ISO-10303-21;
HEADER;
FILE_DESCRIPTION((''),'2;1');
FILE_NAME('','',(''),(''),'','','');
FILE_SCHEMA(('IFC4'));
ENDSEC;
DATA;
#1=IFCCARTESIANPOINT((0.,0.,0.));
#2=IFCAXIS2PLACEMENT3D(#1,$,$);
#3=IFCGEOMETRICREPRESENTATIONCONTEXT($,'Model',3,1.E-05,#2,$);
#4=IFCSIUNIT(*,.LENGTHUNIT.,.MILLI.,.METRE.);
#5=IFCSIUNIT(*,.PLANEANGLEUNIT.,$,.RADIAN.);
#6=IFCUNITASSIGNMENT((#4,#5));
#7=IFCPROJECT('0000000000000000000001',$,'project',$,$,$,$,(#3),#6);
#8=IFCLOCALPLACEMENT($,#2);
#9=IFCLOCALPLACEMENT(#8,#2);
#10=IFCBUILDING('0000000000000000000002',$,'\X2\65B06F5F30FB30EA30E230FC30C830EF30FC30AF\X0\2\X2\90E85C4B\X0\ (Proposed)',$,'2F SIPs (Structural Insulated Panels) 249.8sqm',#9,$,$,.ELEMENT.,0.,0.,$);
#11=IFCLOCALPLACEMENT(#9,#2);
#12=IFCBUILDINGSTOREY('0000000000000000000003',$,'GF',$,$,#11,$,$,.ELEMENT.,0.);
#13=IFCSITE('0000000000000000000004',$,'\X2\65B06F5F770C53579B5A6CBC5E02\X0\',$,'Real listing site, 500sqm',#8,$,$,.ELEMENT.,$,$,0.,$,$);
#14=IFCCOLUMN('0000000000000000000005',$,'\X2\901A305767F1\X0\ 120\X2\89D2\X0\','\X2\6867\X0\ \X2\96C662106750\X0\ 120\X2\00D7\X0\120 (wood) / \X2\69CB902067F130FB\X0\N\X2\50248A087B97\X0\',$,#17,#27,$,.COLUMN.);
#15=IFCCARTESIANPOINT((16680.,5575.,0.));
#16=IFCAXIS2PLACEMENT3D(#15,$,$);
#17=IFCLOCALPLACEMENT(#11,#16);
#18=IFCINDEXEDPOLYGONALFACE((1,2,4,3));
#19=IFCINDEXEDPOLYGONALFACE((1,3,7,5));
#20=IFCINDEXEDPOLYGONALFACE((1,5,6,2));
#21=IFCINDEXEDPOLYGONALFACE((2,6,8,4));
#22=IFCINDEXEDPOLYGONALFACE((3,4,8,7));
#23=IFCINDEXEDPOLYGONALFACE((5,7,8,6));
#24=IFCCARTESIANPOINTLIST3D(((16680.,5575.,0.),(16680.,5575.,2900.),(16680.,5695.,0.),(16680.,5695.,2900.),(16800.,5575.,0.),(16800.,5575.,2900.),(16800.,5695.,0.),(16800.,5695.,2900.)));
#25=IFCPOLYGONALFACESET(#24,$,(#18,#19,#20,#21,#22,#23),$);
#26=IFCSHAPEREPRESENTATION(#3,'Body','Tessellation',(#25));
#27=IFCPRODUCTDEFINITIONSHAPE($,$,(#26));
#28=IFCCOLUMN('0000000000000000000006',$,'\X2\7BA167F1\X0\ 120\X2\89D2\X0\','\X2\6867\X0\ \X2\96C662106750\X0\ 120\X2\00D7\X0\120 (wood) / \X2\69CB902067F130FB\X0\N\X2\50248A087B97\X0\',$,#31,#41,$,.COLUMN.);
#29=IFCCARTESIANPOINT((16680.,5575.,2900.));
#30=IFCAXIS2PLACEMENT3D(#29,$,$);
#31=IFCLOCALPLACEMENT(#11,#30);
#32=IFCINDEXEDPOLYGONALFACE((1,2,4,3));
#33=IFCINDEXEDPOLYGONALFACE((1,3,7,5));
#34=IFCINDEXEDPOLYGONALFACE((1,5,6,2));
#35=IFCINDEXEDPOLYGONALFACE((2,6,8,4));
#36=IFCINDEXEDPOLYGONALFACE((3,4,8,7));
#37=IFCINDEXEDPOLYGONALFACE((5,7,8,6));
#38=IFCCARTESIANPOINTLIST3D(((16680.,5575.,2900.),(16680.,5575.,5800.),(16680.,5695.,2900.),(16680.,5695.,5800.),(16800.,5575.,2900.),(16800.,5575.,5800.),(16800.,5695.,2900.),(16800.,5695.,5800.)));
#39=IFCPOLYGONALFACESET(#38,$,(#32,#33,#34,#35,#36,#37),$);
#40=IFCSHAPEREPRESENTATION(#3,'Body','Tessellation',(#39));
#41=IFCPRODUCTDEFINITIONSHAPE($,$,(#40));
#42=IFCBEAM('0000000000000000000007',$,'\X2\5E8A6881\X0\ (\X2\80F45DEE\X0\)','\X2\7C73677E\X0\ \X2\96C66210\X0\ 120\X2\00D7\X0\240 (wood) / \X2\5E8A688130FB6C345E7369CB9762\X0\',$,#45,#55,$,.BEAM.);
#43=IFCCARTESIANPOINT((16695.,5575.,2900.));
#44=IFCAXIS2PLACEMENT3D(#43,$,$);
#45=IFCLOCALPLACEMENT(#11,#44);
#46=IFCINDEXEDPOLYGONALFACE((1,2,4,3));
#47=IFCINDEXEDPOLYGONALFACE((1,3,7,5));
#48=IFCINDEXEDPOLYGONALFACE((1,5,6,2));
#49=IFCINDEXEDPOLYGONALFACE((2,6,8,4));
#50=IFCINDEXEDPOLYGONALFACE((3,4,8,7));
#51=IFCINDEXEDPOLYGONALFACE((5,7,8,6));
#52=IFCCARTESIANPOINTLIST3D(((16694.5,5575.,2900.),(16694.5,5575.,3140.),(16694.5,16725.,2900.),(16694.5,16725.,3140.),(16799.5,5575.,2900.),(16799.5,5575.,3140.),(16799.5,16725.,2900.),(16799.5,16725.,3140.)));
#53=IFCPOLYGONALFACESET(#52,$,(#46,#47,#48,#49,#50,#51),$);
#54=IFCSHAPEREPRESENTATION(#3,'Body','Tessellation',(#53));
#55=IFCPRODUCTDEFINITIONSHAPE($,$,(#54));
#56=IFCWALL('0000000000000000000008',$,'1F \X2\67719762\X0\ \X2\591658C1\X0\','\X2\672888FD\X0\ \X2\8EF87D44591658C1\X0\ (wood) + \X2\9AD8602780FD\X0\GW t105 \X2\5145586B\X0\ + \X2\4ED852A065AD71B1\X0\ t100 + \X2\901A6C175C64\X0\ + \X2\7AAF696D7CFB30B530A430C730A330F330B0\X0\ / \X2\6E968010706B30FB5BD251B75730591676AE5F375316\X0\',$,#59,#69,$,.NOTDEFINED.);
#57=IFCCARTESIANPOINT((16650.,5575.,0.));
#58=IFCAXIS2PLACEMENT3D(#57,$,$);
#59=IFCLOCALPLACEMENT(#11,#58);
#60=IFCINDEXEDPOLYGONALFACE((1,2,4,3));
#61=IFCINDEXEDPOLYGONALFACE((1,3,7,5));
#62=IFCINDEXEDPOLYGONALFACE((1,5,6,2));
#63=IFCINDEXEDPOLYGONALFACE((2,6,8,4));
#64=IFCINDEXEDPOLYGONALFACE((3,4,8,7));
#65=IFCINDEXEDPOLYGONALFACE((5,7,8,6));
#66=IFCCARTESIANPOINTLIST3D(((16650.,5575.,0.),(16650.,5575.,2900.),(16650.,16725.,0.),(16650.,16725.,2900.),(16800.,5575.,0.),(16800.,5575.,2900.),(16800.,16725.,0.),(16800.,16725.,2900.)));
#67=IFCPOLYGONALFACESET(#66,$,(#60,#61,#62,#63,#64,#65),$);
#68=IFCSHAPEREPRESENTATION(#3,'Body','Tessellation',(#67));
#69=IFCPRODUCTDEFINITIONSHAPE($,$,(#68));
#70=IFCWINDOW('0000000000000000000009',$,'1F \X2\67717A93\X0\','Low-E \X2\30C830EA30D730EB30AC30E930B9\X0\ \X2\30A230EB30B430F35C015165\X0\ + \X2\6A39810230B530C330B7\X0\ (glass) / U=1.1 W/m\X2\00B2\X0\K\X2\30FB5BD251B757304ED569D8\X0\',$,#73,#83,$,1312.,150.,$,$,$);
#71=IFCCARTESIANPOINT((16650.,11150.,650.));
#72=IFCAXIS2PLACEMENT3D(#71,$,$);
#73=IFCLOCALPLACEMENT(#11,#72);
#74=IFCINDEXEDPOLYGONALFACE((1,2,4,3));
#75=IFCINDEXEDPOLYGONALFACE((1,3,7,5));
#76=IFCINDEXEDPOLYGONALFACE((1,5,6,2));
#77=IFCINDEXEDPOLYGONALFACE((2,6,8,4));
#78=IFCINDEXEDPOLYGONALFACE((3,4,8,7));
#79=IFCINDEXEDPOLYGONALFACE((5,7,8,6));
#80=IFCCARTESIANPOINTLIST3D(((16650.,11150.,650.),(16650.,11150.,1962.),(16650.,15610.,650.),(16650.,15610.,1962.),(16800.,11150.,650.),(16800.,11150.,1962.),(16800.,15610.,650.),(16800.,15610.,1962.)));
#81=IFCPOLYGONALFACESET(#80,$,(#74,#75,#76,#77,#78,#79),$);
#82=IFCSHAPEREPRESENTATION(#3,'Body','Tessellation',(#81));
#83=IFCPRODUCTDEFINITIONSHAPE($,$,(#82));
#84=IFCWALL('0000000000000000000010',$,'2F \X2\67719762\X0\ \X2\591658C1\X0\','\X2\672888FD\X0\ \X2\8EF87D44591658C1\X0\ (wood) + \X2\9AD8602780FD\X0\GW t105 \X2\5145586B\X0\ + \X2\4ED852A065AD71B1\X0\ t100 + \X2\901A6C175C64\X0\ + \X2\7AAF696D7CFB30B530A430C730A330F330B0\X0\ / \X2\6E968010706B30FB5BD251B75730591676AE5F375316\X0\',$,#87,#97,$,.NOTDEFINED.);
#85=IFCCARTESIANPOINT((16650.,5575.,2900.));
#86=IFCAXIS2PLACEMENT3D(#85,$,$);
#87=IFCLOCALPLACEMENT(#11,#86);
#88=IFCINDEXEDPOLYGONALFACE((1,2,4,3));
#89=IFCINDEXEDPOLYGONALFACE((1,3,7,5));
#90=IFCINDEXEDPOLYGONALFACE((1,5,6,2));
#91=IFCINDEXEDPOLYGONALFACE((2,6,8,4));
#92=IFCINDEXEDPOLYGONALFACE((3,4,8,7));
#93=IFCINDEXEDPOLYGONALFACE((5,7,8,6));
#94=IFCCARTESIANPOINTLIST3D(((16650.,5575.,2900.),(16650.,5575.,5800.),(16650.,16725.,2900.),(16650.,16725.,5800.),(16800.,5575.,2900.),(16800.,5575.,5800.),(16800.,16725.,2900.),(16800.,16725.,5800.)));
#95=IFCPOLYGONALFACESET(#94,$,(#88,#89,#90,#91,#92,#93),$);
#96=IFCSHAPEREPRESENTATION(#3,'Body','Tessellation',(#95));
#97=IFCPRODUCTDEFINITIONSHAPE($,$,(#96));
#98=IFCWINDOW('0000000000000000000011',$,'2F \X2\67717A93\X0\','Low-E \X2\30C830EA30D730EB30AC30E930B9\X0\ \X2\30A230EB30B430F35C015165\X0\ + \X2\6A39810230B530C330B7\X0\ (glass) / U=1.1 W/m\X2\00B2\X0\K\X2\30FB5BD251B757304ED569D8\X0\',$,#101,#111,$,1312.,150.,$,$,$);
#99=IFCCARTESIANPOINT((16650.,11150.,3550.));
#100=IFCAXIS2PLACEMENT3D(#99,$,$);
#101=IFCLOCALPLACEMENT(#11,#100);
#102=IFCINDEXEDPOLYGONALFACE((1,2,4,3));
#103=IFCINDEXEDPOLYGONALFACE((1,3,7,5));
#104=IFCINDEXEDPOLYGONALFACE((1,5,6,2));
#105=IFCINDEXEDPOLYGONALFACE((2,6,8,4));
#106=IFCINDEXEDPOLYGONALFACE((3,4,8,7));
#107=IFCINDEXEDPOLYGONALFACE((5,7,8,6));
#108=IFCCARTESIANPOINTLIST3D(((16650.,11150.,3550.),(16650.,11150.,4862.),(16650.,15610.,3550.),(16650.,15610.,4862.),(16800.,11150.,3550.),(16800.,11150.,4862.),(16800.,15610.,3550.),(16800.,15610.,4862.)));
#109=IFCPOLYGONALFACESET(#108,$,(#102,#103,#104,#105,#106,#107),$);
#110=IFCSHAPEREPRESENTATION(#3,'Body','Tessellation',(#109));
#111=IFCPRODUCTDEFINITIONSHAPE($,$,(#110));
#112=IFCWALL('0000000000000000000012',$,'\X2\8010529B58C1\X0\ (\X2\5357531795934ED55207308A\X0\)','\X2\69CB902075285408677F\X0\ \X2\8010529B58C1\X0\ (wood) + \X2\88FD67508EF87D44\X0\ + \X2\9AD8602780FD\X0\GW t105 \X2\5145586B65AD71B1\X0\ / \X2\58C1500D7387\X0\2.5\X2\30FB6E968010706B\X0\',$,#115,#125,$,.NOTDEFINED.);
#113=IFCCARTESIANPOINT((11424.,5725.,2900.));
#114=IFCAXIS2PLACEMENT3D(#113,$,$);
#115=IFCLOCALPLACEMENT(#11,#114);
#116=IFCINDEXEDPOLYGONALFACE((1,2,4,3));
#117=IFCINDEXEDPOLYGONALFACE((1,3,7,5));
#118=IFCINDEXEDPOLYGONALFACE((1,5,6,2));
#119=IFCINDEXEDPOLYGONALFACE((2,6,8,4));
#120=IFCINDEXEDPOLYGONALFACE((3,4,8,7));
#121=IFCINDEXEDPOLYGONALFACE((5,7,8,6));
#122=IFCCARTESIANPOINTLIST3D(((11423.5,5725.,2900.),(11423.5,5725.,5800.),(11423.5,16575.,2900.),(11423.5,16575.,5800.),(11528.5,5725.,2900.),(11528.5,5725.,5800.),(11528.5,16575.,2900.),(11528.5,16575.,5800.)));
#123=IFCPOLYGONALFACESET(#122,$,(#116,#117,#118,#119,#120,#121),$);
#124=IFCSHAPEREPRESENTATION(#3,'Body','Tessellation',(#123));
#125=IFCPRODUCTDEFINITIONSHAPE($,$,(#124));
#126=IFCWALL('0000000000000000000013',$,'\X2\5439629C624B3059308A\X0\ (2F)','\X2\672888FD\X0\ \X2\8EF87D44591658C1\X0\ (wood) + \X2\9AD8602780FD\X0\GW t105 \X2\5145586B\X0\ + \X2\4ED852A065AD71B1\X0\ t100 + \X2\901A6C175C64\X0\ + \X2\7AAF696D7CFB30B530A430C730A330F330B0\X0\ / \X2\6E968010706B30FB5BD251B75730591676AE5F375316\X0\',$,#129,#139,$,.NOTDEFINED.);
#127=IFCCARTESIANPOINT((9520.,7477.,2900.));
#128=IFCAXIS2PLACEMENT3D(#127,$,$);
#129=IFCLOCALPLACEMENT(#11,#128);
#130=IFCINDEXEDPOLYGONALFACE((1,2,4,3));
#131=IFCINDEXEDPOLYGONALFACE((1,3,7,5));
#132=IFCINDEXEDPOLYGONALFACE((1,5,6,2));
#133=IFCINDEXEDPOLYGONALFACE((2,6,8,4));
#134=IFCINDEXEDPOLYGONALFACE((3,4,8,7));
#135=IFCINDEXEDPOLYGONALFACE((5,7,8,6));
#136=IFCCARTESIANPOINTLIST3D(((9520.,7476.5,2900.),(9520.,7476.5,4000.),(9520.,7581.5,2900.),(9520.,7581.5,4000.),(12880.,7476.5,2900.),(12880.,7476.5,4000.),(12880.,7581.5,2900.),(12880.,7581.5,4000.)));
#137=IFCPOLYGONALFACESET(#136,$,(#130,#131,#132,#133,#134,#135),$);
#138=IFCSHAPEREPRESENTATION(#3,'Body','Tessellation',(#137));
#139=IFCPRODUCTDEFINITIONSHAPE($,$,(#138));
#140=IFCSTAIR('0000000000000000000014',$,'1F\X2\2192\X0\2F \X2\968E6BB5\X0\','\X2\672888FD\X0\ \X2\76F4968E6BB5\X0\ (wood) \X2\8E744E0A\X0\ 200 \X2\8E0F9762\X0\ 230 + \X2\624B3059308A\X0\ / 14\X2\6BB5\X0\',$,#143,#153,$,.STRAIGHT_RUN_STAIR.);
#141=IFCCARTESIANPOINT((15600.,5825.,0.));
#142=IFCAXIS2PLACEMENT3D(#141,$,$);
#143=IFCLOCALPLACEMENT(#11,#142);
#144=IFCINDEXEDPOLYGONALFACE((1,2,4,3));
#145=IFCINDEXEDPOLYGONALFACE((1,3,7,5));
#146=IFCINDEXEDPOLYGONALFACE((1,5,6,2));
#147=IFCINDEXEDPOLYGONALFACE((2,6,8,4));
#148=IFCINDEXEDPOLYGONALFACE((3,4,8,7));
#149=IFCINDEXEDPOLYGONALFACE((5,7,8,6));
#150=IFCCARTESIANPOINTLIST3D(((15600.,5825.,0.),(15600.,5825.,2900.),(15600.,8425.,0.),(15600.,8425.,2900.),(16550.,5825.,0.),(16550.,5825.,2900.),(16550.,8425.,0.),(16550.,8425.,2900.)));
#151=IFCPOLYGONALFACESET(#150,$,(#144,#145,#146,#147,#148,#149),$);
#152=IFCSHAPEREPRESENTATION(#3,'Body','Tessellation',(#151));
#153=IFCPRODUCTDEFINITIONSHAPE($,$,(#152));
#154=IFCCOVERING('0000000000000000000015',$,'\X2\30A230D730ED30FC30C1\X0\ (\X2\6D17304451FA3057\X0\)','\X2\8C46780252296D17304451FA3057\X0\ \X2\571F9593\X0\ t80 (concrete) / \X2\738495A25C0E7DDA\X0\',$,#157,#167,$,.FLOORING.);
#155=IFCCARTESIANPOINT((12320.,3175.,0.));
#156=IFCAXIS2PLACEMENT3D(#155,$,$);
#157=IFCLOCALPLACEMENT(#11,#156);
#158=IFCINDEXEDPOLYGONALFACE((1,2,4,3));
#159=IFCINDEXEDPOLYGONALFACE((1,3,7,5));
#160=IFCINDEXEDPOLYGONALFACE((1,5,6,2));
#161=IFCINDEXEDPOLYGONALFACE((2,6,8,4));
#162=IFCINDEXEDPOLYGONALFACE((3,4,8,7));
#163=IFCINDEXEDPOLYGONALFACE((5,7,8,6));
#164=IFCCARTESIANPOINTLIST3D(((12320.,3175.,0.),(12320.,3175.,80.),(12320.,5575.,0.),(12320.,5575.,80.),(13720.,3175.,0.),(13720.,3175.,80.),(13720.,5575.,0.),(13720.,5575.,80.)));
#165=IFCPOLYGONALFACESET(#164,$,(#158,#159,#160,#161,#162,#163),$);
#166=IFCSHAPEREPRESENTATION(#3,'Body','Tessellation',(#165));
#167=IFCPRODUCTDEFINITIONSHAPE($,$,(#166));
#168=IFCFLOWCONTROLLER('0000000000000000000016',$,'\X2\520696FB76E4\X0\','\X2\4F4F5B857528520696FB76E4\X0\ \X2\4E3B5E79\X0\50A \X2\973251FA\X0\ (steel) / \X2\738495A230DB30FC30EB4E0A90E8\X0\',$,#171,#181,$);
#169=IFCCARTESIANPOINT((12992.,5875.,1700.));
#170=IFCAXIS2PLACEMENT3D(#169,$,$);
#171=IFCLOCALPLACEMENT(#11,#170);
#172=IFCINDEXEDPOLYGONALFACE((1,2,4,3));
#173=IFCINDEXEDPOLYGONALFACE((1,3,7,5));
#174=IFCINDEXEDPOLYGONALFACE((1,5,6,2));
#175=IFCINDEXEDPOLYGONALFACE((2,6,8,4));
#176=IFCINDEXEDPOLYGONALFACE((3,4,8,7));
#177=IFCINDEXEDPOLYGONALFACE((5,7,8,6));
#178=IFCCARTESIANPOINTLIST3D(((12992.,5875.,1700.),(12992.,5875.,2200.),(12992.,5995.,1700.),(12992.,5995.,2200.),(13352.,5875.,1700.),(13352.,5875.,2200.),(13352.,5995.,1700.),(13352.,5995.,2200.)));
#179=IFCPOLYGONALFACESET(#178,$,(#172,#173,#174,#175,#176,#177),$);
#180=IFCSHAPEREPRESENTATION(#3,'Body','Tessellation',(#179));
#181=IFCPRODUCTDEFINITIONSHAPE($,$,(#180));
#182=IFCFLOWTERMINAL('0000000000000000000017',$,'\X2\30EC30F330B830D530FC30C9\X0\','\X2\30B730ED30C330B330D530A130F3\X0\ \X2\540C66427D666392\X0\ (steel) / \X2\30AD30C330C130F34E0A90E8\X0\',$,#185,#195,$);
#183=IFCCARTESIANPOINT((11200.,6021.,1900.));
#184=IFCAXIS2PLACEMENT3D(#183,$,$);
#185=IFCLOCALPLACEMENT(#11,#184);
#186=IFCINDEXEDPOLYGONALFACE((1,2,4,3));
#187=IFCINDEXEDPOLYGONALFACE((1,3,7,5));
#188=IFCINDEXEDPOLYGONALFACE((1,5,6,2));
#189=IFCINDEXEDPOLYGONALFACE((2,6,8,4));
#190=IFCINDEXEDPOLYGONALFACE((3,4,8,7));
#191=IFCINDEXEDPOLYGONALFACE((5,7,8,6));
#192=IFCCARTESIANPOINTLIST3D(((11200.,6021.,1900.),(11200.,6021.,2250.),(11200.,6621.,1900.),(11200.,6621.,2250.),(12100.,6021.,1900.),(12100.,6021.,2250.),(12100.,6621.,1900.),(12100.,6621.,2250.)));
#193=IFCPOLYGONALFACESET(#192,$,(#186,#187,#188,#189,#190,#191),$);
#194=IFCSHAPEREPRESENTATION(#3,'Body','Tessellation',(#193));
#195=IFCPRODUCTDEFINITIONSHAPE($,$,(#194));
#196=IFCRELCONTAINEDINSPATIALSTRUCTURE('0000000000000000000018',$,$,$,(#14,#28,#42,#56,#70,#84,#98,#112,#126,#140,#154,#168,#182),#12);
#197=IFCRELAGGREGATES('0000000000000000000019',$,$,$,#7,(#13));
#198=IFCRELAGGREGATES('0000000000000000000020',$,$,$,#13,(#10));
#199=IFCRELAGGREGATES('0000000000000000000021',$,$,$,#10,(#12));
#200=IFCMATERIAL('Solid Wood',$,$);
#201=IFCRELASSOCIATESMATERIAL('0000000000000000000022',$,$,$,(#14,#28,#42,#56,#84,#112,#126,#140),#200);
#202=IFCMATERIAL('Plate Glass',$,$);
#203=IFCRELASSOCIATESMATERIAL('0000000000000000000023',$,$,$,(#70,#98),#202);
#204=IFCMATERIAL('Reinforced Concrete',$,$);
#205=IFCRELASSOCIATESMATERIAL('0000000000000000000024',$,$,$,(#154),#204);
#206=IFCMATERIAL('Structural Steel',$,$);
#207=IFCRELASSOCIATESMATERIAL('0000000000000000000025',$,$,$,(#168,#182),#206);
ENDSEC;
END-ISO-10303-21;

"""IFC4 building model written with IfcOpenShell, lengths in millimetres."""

from ifc_helpers import new_model, si_unit, frame, frame_2d, origin, place, context, project, spatial, rectangle, extrude, material, element, fill, save


model = new_model("IFC4")

# Units and contexts
model_context = context("Model", 3, precision=1e-05, world=origin())
ifc_project = project(units=[si_unit("LENGTHUNIT", "METRE", prefix="MILLI"), si_unit("PLANEANGLEUNIT", "RADIAN")], contexts=[model_context])

# Site, building, storey
site_placement = place(None, origin())
site = spatial("IfcSite", under=ifc_project, at=site_placement, Name="新潟県南魚沼市", ObjectType="Real listing site, 500sqm", CompositionType="ELEMENT", RefElevation=0.0)
building_placement = place(site_placement, origin())
building = spatial("IfcBuilding", under=site, at=building_placement, Name="新潟・リモートワーク2部屋 (Proposed)", ObjectType="2F SIPs (Structural Insulated Panels) 249.8sqm", CompositionType="ELEMENT", ElevationOfRefHeight=0.0, ElevationOfTerrain=0.0)
storey_placement = place(building_placement, origin())
storey = spatial("IfcBuildingStorey", under=building, at=storey_placement, Name="GF", CompositionType="ELEMENT", Elevation=0.0)

# Columns
ifc_material_1 = material(Name="Solid Wood")
column_1_placement = place(storey_placement, frame((16680.0, 5575.0, 0.0)))
element("IfcColumn", 1, at=column_1_placement, inside=storey, material=ifc_material_1, Name="通し柱 120角", Description="桧 集成材 120×120 (wood) / 構造柱・N値計算", PredefinedType="COLUMN", context=model_context, shape_type="SweptSolid", body=[
    extrude(rectangle(XDim=120.0, YDim=120.0, at=frame_2d((60.0, 60.0))), frame((16680.0, 5575.0, 0.0)), (0.0, 0.0, 1.0), 2900.0),
])
column_2_placement = place(storey_placement, frame((16680.0, 5575.0, 2900.0)))
element("IfcColumn", 2, at=column_2_placement, inside=storey, material=ifc_material_1, Name="管柱 120角", Description="桧 集成材 120×120 (wood) / 構造柱・N値計算", PredefinedType="COLUMN", context=model_context, shape_type="SweptSolid", body=[
    extrude(rectangle(XDim=120.0, YDim=120.0, at=frame_2d((60.0, 60.0))), frame((16680.0, 5575.0, 2900.0)), (0.0, 0.0, 1.0), 2900.0),
])

# Beam
beam_1_placement = place(storey_placement, frame((16695.0, 5575.0, 2900.0)))
element("IfcBeam", 3, at=beam_1_placement, inside=storey, material=ifc_material_1, Name="床梁 (胴差)", Description="米松 集成 120×240 (wood) / 床梁・水平構面", PredefinedType="BEAM", context=model_context, shape_type="SweptSolid", body=[
    extrude(rectangle(XDim=105.0, YDim=11150.0, at=frame_2d((52.0, 5575.0))), frame((16695.0, 5575.0, 2900.0)), (0.0, 0.0, 1.0), 240.0),
])

# Wall, opening, window
wall_1_placement = place(storey_placement, frame((16650.0, 5575.0, 0.0)))
wall_1 = element("IfcWall", 4, at=wall_1_placement, inside=storey, material=ifc_material_1, Name="1F 東面 外壁", Description="木製 軸組外壁 (wood) + 高性能GW t105 充填 + 付加断熱 t100 + 通気層 + 窯業系サイディング / 準耐火・寒冷地外皮強化", PredefinedType="NOTDEFINED", context=model_context, shape_type="SweptSolid", body=[
    extrude(rectangle(XDim=150.0, YDim=11150.0, at=frame_2d((75.0, 5575.0))), frame((16650.0, 5575.0, 0.0)), (0.0, 0.0, 1.0), 2900.0),
])
opening_1_placement = place(storey_placement, frame((16650.0, 11150.0, 650.0)))
opening_1 = element("IfcOpeningElement", 5, at=opening_1_placement, cuts=wall_1, PredefinedType="NOTDEFINED", context=model_context, shape_type="SweptSolid", body=[
    extrude(rectangle(XDim=150.0, YDim=4460.0, at=frame_2d((75.0, 2230.0))), frame((16650.0, 11150.0, 650.0)), (0.0, 0.0, 1.0), 1312.0),
])
ifc_material_2 = material(Name="Plate Glass")
window_1_placement = place(storey_placement, frame((16650.0, 11150.0, 650.0)))
window_1 = element("IfcWindow", 6, at=window_1_placement, inside=storey, material=ifc_material_2, Name="1F 東窓", Description="Low-E トリプルガラス アルゴン封入 + 樹脂サッシ (glass) / U=1.1 W/m²K・寒冷地仕様", OverallHeight=1312.0, OverallWidth=150.0, context=model_context, shape_type="SweptSolid", body=[
    extrude(rectangle(XDim=150.0, YDim=4460.0, at=frame_2d((75.0, 2230.0))), frame((16650.0, 11150.0, 650.0)), (0.0, 0.0, 1.0), 1312.0),
])
fill(opening_1, window_1)

# Wall, opening, window
wall_2_placement = place(storey_placement, frame((16650.0, 5575.0, 2900.0)))
wall_2 = element("IfcWall", 7, at=wall_2_placement, inside=storey, material=ifc_material_1, Name="2F 東面 外壁", Description="木製 軸組外壁 (wood) + 高性能GW t105 充填 + 付加断熱 t100 + 通気層 + 窯業系サイディング / 準耐火・寒冷地外皮強化", PredefinedType="NOTDEFINED", context=model_context, shape_type="SweptSolid", body=[
    extrude(rectangle(XDim=150.0, YDim=11150.0, at=frame_2d((75.0, 5575.0))), frame((16650.0, 5575.0, 2900.0)), (0.0, 0.0, 1.0), 2900.0),
])
opening_2_placement = place(storey_placement, frame((16650.0, 11150.0, 3550.0)))
opening_2 = element("IfcOpeningElement", 8, at=opening_2_placement, cuts=wall_2, PredefinedType="NOTDEFINED", context=model_context, shape_type="SweptSolid", body=[
    extrude(rectangle(XDim=150.0, YDim=4460.0, at=frame_2d((75.0, 2230.0))), frame((16650.0, 11150.0, 3550.0)), (0.0, 0.0, 1.0), 1312.0),
])
window_2_placement = place(storey_placement, frame((16650.0, 11150.0, 3550.0)))
window_2 = element("IfcWindow", 9, at=window_2_placement, inside=storey, material=ifc_material_2, Name="2F 東窓", Description="Low-E トリプルガラス アルゴン封入 + 樹脂サッシ (glass) / U=1.1 W/m²K・寒冷地仕様", OverallHeight=1312.0, OverallWidth=150.0, context=model_context, shape_type="SweptSolid", body=[
    extrude(rectangle(XDim=150.0, YDim=4460.0, at=frame_2d((75.0, 2230.0))), frame((16650.0, 11150.0, 3550.0)), (0.0, 0.0, 1.0), 1312.0),
])
fill(opening_2, window_2)

# Walls
wall_3_placement = place(storey_placement, frame((11424.0, 5725.0, 2900.0)))
element("IfcWall", 10, at=wall_3_placement, inside=storey, material=ifc_material_1, Name="耐力壁 (南北間仕切り)", Description="構造用合板 耐力壁 (wood) + 製材軸組 + 高性能GW t105 充填断熱 / 壁倍率2.5・準耐火", PredefinedType="NOTDEFINED", context=model_context, shape_type="SweptSolid", body=[
    extrude(rectangle(XDim=105.0, YDim=10850.0, at=frame_2d((52.0, 5425.0))), frame((11424.0, 5725.0, 2900.0)), (0.0, 0.0, 1.0), 2900.0),
])
wall_4_placement = place(storey_placement, frame((9520.0, 7477.0, 2900.0)))
element("IfcWall", 11, at=wall_4_placement, inside=storey, material=ifc_material_1, Name="吹抜手すり (2F)", Description="木製 軸組外壁 (wood) + 高性能GW t105 充填 + 付加断熱 t100 + 通気層 + 窯業系サイディング / 準耐火・寒冷地外皮強化", PredefinedType="NOTDEFINED", context=model_context, shape_type="SweptSolid", body=[
    extrude(rectangle(XDim=3360.0, YDim=105.0, at=frame_2d((1680.0, 52.0))), frame((9520.0, 7477.0, 2900.0)), (0.0, 0.0, 1.0), 1100.0),
])

# Stair
stair_placement = place(storey_placement, frame((15600.0, 5825.0, 0.0)))
element("IfcStair", 12, at=stair_placement, inside=storey, material=ifc_material_1, Name="1F→2F 階段", Description="木製 直階段 (wood) 蹴上 200 踏面 230 + 手すり / 14段", PredefinedType="STRAIGHT_RUN_STAIR", context=model_context, shape_type="SweptSolid", body=[
    extrude(rectangle(XDim=950.0, YDim=2600.0, at=frame_2d((475.0, 1300.0))), frame((15600.0, 5825.0, 0.0)), (0.0, 0.0, 1.0), 2900.0),
])

# Covering
ifc_material_3 = material(Name="Reinforced Concrete")
covering_placement = place(storey_placement, frame((12320.0, 3175.0, 0.0)))
element("IfcCovering", 13, at=covering_placement, inside=storey, material=ifc_material_3, Name="アプローチ (洗い出し)", Description="豆砂利洗い出し 土間 t80 (concrete) / 玄関導線", PredefinedType="FLOORING", context=model_context, shape_type="SweptSolid", body=[
    extrude(rectangle(XDim=1400.0, YDim=2400.0, at=frame_2d((700.0, 1200.0))), frame((12320.0, 3175.0, 0.0)), (0.0, 0.0, 1.0), 80.0),
])

# Flow controller
ifc_material_4 = material(Name="Structural Steel")
flow_controller_placement = place(storey_placement, frame((12992.0, 5875.0, 1700.0)))
element("IfcFlowController", 14, at=flow_controller_placement, inside=storey, material=ifc_material_4, Name="分電盤", Description="住宅用分電盤 主幹50A 露出 (steel) / 玄関ホール上部", context=model_context, shape_type="SweptSolid", body=[
    extrude(rectangle(XDim=360.0, YDim=120.0, at=frame_2d((180.0, 60.0))), frame((12992.0, 5875.0, 1700.0)), (0.0, 0.0, 1.0), 500.0),
])

# Flow terminal
flow_terminal_1_placement = place(storey_placement, frame((11200.0, 6021.0, 1900.0)))
element("IfcFlowTerminal", 15, at=flow_terminal_1_placement, inside=storey, material=ifc_material_4, Name="レンジフード", Description="シロッコファン 同時給排 (steel) / キッチン上部", context=model_context, shape_type="SweptSolid", body=[
    extrude(rectangle(XDim=900.0, YDim=600.0, at=frame_2d((450.0, 300.0))), frame((11200.0, 6021.0, 1900.0)), (0.0, 0.0, 1.0), 350.0),
])

save(model, "model.ifc")
